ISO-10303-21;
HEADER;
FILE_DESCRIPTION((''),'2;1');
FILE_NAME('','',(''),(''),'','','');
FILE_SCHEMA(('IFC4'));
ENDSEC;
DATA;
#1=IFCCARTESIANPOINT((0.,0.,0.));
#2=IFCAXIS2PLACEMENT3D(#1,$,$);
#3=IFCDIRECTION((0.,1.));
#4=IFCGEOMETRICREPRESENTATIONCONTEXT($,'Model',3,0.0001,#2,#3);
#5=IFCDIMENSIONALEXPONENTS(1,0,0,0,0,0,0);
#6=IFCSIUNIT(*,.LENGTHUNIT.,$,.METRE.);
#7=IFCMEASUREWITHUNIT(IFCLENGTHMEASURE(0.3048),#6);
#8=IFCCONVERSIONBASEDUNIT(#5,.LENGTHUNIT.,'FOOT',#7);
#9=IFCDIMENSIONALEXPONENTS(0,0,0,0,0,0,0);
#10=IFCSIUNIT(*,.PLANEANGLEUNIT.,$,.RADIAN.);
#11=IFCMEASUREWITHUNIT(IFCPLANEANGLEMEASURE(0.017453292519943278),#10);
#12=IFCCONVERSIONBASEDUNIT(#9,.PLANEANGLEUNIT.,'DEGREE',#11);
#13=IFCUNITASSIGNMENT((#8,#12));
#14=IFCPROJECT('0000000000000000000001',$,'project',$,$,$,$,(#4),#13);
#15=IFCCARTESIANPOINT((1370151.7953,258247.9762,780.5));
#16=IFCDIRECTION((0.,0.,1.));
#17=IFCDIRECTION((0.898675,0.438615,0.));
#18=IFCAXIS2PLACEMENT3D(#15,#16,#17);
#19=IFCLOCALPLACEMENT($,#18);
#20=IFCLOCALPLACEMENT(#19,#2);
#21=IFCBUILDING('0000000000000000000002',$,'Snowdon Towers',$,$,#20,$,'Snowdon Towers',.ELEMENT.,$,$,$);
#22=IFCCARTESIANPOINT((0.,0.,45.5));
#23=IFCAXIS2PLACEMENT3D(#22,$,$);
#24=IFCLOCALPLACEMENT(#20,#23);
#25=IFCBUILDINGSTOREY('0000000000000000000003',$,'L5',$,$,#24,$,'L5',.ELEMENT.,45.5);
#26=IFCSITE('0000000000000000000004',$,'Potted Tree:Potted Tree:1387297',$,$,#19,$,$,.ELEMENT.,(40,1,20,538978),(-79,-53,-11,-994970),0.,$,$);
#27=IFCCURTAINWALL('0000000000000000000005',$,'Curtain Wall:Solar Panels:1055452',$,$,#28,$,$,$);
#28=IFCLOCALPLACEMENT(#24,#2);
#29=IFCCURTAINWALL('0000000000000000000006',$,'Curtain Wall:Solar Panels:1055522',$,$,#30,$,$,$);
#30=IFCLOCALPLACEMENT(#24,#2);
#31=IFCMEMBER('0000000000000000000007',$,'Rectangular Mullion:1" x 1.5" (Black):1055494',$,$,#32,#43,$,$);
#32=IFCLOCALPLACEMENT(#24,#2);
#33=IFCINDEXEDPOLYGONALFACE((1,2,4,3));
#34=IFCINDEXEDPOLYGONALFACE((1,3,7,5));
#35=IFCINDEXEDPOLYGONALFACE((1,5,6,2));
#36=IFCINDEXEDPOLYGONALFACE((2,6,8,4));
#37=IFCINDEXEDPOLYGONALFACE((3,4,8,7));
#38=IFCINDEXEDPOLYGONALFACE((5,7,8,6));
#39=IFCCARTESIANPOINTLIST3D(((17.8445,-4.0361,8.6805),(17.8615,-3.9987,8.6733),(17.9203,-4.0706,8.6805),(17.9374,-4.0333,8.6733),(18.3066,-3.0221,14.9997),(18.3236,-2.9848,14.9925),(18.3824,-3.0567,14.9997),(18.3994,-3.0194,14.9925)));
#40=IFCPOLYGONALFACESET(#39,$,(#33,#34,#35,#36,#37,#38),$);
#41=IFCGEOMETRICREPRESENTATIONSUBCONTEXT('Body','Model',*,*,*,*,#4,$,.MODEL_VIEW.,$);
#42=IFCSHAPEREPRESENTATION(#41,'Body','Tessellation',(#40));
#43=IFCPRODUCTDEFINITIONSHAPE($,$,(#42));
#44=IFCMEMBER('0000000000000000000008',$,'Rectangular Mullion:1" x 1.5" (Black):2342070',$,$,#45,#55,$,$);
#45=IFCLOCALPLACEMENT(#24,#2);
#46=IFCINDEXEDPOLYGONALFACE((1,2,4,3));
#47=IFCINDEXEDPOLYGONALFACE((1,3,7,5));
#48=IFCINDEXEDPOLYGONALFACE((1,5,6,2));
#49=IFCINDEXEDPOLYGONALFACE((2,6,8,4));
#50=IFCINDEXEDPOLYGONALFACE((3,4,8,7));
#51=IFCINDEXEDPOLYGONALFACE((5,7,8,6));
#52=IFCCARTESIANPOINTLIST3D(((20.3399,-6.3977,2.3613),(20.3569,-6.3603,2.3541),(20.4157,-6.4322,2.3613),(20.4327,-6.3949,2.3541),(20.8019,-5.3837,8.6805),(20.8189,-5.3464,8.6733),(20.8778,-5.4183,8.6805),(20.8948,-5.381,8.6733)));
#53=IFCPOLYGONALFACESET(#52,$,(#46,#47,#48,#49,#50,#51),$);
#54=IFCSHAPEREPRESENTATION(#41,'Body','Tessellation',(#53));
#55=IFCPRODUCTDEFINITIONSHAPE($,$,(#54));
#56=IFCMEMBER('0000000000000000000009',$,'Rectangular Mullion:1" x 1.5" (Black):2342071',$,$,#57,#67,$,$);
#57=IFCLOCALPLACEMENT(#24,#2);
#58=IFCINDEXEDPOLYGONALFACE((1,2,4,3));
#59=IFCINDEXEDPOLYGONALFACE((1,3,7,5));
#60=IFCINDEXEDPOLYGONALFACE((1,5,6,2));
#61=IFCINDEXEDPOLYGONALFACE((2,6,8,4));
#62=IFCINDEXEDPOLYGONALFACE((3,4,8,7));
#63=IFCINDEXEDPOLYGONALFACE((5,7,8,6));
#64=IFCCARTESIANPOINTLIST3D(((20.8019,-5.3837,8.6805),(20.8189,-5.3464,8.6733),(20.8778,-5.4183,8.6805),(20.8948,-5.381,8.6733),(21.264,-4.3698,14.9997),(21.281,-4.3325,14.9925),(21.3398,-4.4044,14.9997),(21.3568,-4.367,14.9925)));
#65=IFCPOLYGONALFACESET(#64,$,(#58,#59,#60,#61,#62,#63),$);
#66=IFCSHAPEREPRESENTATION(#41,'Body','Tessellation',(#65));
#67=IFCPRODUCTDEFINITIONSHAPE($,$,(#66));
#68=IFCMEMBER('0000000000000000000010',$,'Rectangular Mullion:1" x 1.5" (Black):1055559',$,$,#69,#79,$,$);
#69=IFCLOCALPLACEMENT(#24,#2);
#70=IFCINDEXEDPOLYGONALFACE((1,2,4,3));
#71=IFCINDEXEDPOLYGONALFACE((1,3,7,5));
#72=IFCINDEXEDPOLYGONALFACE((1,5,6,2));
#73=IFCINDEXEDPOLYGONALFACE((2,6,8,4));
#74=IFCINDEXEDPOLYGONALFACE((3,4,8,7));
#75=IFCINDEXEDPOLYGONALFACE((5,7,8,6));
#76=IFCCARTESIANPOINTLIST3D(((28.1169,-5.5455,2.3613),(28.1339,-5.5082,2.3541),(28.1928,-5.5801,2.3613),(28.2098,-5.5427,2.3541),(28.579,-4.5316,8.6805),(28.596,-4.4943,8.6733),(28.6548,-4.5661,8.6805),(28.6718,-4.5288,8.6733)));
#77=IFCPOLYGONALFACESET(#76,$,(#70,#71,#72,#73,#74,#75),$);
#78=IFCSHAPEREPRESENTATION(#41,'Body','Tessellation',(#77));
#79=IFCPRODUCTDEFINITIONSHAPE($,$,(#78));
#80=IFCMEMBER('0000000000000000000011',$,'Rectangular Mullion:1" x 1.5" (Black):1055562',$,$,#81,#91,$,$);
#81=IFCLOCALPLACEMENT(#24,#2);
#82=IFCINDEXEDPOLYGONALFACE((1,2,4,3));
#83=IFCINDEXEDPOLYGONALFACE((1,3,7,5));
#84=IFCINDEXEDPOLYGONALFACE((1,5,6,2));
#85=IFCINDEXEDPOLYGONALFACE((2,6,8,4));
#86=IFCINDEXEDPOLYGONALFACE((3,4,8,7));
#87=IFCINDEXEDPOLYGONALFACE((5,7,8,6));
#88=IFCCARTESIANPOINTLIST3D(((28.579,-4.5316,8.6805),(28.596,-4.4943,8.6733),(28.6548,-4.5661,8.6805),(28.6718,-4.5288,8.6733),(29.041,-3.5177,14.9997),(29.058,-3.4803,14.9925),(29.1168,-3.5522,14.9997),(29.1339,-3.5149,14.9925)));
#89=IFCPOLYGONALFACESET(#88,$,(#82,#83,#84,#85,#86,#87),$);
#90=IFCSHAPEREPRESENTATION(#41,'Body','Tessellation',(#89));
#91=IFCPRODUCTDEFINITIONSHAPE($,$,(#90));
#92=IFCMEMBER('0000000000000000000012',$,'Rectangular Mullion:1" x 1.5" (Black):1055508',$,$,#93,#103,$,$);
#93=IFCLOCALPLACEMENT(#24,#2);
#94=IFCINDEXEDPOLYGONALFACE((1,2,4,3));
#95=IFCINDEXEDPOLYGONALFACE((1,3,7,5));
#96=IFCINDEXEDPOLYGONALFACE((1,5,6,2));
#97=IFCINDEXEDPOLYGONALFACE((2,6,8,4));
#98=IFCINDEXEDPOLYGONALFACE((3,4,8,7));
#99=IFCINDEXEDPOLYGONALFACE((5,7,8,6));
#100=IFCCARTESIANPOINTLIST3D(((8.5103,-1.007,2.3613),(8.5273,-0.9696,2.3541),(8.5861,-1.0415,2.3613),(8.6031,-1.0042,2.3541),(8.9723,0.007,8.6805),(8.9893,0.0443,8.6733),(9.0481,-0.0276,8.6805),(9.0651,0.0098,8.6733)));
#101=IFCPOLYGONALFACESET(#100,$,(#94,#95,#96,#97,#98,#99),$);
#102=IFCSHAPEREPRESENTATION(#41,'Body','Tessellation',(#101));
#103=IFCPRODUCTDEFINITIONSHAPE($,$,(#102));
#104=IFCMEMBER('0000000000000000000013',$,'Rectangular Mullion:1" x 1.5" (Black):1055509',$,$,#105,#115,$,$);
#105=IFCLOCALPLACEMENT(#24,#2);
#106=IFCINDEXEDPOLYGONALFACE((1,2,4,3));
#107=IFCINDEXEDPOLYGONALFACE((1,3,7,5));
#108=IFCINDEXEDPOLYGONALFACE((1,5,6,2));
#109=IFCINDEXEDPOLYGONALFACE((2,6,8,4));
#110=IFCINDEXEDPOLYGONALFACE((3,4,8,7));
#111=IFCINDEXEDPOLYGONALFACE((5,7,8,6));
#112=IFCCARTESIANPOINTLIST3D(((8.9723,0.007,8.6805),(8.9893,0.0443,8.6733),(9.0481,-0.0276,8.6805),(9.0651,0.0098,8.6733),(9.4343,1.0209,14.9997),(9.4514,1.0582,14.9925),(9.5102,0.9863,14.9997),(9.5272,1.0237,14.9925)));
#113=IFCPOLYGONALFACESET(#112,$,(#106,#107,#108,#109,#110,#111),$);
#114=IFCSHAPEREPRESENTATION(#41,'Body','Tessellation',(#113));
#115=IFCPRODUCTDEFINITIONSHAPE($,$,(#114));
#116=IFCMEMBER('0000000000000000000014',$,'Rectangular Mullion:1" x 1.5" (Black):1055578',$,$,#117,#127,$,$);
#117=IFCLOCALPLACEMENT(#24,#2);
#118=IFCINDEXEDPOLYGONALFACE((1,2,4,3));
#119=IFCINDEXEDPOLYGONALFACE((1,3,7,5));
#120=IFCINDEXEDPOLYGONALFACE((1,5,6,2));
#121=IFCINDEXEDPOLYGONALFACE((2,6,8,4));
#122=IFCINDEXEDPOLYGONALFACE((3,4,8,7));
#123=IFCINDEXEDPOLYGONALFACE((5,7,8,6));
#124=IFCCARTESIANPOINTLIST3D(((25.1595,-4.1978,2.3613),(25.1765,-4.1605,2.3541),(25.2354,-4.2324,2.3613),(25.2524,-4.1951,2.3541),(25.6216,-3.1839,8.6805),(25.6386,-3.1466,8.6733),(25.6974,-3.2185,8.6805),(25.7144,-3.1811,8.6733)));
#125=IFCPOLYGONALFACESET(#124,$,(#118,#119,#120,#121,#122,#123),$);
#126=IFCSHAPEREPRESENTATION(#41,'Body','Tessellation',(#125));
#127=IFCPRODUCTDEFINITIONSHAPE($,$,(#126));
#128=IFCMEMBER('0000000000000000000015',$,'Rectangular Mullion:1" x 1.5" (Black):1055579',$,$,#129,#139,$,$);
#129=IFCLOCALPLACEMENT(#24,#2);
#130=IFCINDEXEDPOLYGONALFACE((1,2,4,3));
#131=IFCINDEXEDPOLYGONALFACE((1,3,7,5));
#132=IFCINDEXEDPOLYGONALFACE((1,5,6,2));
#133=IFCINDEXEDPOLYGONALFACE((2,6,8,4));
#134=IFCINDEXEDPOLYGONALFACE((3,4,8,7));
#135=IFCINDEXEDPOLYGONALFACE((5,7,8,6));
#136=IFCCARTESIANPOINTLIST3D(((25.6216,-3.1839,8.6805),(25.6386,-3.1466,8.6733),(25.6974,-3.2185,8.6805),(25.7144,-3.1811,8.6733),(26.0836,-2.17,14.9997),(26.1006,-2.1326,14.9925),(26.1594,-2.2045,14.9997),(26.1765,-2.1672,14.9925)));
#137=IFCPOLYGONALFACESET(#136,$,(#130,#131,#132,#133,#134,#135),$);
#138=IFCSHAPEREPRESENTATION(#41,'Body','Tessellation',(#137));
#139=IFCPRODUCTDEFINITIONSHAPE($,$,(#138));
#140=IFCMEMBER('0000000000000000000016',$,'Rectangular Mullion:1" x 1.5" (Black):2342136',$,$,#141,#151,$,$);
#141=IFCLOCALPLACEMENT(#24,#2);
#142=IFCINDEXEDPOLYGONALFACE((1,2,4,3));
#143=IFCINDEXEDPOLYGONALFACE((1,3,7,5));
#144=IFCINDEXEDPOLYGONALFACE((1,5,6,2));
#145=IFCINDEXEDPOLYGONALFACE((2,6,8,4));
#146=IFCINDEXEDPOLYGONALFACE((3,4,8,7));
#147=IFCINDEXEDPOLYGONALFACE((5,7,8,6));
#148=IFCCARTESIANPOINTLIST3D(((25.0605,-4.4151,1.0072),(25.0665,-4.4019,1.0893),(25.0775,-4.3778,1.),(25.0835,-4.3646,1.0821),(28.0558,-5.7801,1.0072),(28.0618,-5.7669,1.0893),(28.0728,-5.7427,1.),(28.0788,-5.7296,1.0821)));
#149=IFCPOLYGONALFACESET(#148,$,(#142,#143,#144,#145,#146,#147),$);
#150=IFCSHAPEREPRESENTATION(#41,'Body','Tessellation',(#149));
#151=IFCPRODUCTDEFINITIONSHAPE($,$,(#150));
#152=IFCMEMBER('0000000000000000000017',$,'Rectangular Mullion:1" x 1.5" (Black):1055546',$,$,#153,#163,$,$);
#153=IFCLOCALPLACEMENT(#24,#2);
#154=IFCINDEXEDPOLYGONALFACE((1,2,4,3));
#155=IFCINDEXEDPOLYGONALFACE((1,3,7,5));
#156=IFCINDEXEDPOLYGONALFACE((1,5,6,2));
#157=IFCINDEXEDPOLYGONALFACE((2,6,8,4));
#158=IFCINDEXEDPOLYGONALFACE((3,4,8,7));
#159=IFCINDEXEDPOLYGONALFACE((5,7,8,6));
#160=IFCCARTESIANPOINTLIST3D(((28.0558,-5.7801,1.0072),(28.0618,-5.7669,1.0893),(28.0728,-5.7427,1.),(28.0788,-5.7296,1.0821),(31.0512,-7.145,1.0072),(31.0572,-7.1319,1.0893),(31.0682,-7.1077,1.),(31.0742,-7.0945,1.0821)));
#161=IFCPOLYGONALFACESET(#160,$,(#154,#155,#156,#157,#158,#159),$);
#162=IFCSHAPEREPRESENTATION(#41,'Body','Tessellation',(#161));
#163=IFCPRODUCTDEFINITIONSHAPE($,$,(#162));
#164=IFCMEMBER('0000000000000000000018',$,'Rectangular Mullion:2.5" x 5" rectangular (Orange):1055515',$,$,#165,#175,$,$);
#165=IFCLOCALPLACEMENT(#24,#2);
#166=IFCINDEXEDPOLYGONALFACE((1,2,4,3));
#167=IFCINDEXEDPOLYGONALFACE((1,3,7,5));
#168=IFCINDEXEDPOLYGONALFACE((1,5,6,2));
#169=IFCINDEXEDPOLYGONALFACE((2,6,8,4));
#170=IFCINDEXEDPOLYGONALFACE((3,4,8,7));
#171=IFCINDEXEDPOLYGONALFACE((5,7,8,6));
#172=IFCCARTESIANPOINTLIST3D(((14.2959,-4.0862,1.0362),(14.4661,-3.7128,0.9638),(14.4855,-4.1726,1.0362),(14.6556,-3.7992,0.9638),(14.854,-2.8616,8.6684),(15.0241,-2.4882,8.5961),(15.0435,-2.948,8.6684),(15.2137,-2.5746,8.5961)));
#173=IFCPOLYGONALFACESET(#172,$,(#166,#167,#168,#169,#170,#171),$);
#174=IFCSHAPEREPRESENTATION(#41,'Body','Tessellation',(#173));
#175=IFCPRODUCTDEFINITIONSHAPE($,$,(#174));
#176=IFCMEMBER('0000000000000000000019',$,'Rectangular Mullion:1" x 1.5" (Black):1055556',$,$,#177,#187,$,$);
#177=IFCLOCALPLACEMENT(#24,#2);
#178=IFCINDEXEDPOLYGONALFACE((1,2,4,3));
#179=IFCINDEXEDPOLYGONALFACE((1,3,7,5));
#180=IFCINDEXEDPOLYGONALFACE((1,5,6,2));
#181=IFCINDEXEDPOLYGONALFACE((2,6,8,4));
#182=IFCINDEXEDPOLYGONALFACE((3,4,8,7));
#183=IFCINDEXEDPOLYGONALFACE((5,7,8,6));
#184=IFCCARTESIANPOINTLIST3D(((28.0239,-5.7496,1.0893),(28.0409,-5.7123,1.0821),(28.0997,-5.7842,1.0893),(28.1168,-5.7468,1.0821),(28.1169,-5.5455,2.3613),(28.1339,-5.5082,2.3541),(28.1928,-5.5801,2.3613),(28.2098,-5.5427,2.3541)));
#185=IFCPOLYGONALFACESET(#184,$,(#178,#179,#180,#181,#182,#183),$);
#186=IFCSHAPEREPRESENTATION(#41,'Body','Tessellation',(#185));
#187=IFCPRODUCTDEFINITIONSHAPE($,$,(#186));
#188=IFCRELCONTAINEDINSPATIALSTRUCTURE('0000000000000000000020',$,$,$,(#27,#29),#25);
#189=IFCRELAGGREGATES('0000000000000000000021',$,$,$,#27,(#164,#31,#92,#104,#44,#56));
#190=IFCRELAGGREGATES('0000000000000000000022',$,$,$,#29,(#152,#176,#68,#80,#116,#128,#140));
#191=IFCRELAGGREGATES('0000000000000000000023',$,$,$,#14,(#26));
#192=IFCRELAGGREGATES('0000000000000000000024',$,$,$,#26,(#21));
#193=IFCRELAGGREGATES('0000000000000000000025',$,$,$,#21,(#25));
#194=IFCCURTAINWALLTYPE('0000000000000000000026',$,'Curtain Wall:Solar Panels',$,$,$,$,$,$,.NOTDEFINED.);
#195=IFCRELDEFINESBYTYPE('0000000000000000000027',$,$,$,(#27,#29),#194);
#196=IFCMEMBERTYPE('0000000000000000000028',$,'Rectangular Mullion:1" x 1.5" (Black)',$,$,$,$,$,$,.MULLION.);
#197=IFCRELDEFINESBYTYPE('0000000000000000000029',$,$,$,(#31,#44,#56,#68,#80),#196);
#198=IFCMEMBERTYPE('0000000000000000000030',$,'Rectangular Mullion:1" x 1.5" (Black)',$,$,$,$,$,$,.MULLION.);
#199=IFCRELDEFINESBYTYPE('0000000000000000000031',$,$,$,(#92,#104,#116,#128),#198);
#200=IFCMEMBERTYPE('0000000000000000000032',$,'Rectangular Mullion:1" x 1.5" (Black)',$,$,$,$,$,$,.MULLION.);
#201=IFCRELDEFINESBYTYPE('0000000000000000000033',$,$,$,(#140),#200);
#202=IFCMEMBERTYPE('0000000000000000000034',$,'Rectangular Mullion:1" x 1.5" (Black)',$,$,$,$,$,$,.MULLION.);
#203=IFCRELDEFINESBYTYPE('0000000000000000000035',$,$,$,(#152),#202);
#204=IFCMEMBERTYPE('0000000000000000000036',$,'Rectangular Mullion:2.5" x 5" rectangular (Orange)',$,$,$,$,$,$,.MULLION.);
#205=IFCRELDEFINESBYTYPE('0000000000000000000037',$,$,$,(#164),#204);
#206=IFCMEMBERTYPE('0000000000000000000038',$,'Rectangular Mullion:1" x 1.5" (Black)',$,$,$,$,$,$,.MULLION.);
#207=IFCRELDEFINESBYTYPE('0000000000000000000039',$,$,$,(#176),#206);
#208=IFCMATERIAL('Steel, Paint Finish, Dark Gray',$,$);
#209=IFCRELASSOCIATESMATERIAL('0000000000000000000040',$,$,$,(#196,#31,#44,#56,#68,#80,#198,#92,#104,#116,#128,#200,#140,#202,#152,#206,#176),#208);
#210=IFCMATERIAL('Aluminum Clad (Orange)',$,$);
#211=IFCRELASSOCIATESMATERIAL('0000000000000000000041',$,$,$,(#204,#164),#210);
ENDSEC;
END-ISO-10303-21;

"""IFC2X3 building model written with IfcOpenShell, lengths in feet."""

from ifc_helpers import new_model, entity, si_unit, converted_unit, direction, frame, frame_2d, origin, origin_2d_with_axis, place, context, subcontext, project, spatial, rectangle, extrude, source, transform, mapped, material, type_object, type_shapes, element, aggregate, save


model = new_model("IFC2X3")

# Units and contexts
model_context = context("Model", 3, precision=0.0001, world=origin(), true_north=direction((0.0, 1.0)))
body_context = subcontext(model_context, "Body", "Model", "MODEL_VIEW")
ifc_project = project(units=[converted_unit("LENGTHUNIT", "FOOT", entity("IfcLengthMeasure", 0.3048), si_unit("LENGTHUNIT", "METRE"), dimensions=[1, 0, 0, 0, 0, 0, 0]), converted_unit("PLANEANGLEUNIT", "DEGREE", entity("IfcPlaneAngleMeasure", 0.017453292519943278), si_unit("PLANEANGLEUNIT", "RADIAN"), dimensions=[0, 0, 0, 0, 0, 0, 0])], contexts=[model_context])

# Site, building, storey
site_placement = place(None, frame((1370151.7953, 258247.9762, 780.5), z_axis=(0.0, 0.0, 1.0), x_axis=(0.898675, 0.438615, 0.0)))
site = spatial("IfcSite", under=ifc_project, at=site_placement, Name="Potted Tree:Potted Tree:1387297", CompositionType="ELEMENT", RefLatitude=(40, 1, 20, 538978), RefLongitude=(-79, -53, -11, -994970), RefElevation=0.0)
building_placement = place(site_placement, origin())
building = spatial("IfcBuilding", under=site, at=building_placement, Name="Snowdon Towers", LongName="Snowdon Towers", CompositionType="ELEMENT")
storey_placement = place(building_placement, frame((0.0, 0.0, 45.5)))
storey = spatial("IfcBuildingStorey", under=building, at=storey_placement, Name="L5", LongName="L5", CompositionType="ELEMENT", Elevation=45.5)

# Curtain wall
curtain_wall_type = type_object("IfcCurtainWallType", Name="Curtain Wall:Solar Panels", PredefinedType="NOTDEFINED")
curtain_wall_1_placement = place(storey_placement, frame((0.0, 0.0, -45.5)))
curtain_wall_1 = element("IfcCurtainWall", 1, at=curtain_wall_1_placement, inside=storey, type_object=curtain_wall_type, Name="Curtain Wall:Solar Panels:1055452")
ifc_material_1 = material(Name="Aluminum Clad (Orange)")

# Curtain wall
curtain_wall_2_placement = place(storey_placement, frame((0.0, 0.0, -45.5)))
curtain_wall_2 = element("IfcCurtainWall", 2, at=curtain_wall_2_placement, inside=storey, type_object=curtain_wall_type, Name="Curtain Wall:Solar Panels:1055522")

# Members
ifc_material_2 = material(Name="Steel, Paint Finish, Dark Gray")
member_type_1 = type_object("IfcMemberType", Name="Rectangular Mullion:1\" x 1.5\" (Black)", PredefinedType="MULLION", material=ifc_material_2)
shared_shape_1 = source(origin(), body_context, "Body", "SweptSolid", [
    extrude(rectangle(XDim=0.0833, YDim=0.0417, at=origin_2d_with_axis()), frame((0.0, 0.0208, -6.4167), z_axis=(0.0, 0.0, 1.0), x_axis=(-1.0, 0.0, 0.0)), (0.0, 0.0, 1.0), 6.4167),
])
type_shapes(member_type_1, [shared_shape_1])
member_1_placement = place(curtain_wall_1_placement, frame((17.8994, -4.016, 54.1733), z_axis=(-0.072007, -0.158015, -0.984808), x_axis=(0.909972, -0.414671, 0.0)))
member_1 = element("IfcMember", 3, at=member_1_placement, type_object=member_type_1, material=ifc_material_2, Name="Rectangular Mullion:1\" x 1.5\" (Black):1055494", context=body_context, shape_type="MappedRepresentation", body=[
    mapped(shared_shape_1, transform((0.0, 0.0, 0.0), scale=1.0)),
])
member_2_placement = place(curtain_wall_1_placement, frame((20.3948, -6.3776, 47.8541), z_axis=(-0.072007, -0.158015, -0.984808), x_axis=(0.909972, -0.414671, 0.0)))
member_2 = element("IfcMember", 4, at=member_2_placement, type_object=member_type_1, material=ifc_material_2, Name="Rectangular Mullion:1\" x 1.5\" (Black):2342070", context=body_context, shape_type="MappedRepresentation", body=[
    mapped(shared_shape_1, transform((0.0, 0.0, 0.0), scale=1.0)),
])
member_3_placement = place(curtain_wall_1_placement, frame((20.8569, -5.3637, 54.1733), z_axis=(-0.072007, -0.158015, -0.984808), x_axis=(0.909972, -0.414671, 0.0)))
member_3 = element("IfcMember", 5, at=member_3_placement, type_object=member_type_1, material=ifc_material_2, Name="Rectangular Mullion:1\" x 1.5\" (Black):2342071", context=body_context, shape_type="MappedRepresentation", body=[
    mapped(shared_shape_1, transform((0.0, 0.0, 0.0), scale=1.0)),
])
member_4_placement = place(curtain_wall_2_placement, frame((28.1719, -5.5255, 47.8541), z_axis=(-0.072007, -0.158015, -0.984808), x_axis=(0.909972, -0.414671, 0.0)))
member_4 = element("IfcMember", 6, at=member_4_placement, type_object=member_type_1, material=ifc_material_2, Name="Rectangular Mullion:1\" x 1.5\" (Black):1055559", context=body_context, shape_type="MappedRepresentation", body=[
    mapped(shared_shape_1, transform((0.0, 0.0, 0.0), scale=1.0)),
])
member_5_placement = place(curtain_wall_2_placement, frame((28.6339, -4.5115, 54.1733), z_axis=(-0.072007, -0.158015, -0.984808), x_axis=(0.909972, -0.414671, 0.0)))
member_5 = element("IfcMember", 7, at=member_5_placement, type_object=member_type_1, material=ifc_material_2, Name="Rectangular Mullion:1\" x 1.5\" (Black):1055562", context=body_context, shape_type="MappedRepresentation", body=[
    mapped(shared_shape_1, transform((0.0, 0.0, 0.0), scale=1.0)),
])
member_type_2 = type_object("IfcMemberType", Name="Rectangular Mullion:1\" x 1.5\" (Black)", PredefinedType="MULLION", material=ifc_material_2)
shared_shape_2 = source(origin(), body_context, "Body", "SweptSolid", [
    extrude(rectangle(XDim=0.0833, YDim=0.0417, at=frame_2d((0.0, 0.0), x_axis=(1.0, 0.0))), frame((-0.0417, 0.0208, -6.4167), z_axis=(0.0, 0.0, 1.0), x_axis=(-1.0, 0.0, 0.0)), (0.0, 0.0, 1.0), 6.4167),
])
type_shapes(member_type_2, [shared_shape_2])
member_6_placement = place(curtain_wall_1_placement, frame((8.9893, 0.0443, 54.1733), z_axis=(0.072007, 0.158015, 0.984808), x_axis=(-0.909972, 0.414671, 0.0)))
member_6 = element("IfcMember", 8, at=member_6_placement, type_object=member_type_2, material=ifc_material_2, Name="Rectangular Mullion:1\" x 1.5\" (Black):1055508", context=body_context, shape_type="MappedRepresentation", body=[
    mapped(shared_shape_2, transform((0.0, 0.0, 0.0), scale=1.0)),
])
member_7_placement = place(curtain_wall_1_placement, frame((9.4514, 1.0582, 60.4925), z_axis=(0.072007, 0.158015, 0.984808), x_axis=(-0.909972, 0.414671, 0.0)))
member_7 = element("IfcMember", 9, at=member_7_placement, type_object=member_type_2, material=ifc_material_2, Name="Rectangular Mullion:1\" x 1.5\" (Black):1055509", context=body_context, shape_type="MappedRepresentation", body=[
    mapped(shared_shape_2, transform((0.0, 0.0, 0.0), scale=1.0)),
])
member_8_placement = place(curtain_wall_2_placement, frame((25.6386, -3.1466, 54.1733), z_axis=(0.072007, 0.158015, 0.984808), x_axis=(-0.909972, 0.414671, 0.0)))
member_8 = element("IfcMember", 10, at=member_8_placement, type_object=member_type_2, material=ifc_material_2, Name="Rectangular Mullion:1\" x 1.5\" (Black):1055578", context=body_context, shape_type="MappedRepresentation", body=[
    mapped(shared_shape_2, transform((0.0, 0.0, 0.0), scale=1.0)),
])
member_9_placement = place(curtain_wall_2_placement, frame((26.1006, -2.1326, 60.4925), z_axis=(0.072007, 0.158015, 0.984808), x_axis=(-0.909972, 0.414671, 0.0)))
member_9 = element("IfcMember", 11, at=member_9_placement, type_object=member_type_2, material=ifc_material_2, Name="Rectangular Mullion:1\" x 1.5\" (Black):1055579", context=body_context, shape_type="MappedRepresentation", body=[
    mapped(shared_shape_2, transform((0.0, 0.0, 0.0), scale=1.0)),
])
member_type_3 = type_object("IfcMemberType", Name="Rectangular Mullion:1\" x 1.5\" (Black)", PredefinedType="MULLION", material=ifc_material_2)
shared_shape_3 = source(origin(), body_context, "Body", "SweptSolid", [
    extrude(rectangle(XDim=0.0833, YDim=0.0417, at=origin_2d_with_axis()), frame((-0.0417, 0.0208, -3.2917), z_axis=(0.0, 0.0, 1.0), x_axis=(-1.0, 0.0, 0.0)), (0.0, 0.0, 1.0), 3.2917),
])
type_shapes(member_type_3, [shared_shape_3])
member_10_placement = place(curtain_wall_2_placement, frame((25.0775, -4.3778, 46.5), z_axis=(-0.909972, 0.414671, 0.0), x_axis=(-0.072007, -0.158015, -0.984808)))
member_10 = element("IfcMember", 12, at=member_10_placement, type_object=member_type_3, material=ifc_material_2, Name="Rectangular Mullion:1\" x 1.5\" (Black):2342136", context=body_context, shape_type="MappedRepresentation", body=[
    mapped(shared_shape_3, transform((0.0, 0.0, 0.0), scale=1.0)),
])
member_type_4 = type_object("IfcMemberType", Name="Rectangular Mullion:1\" x 1.5\" (Black)", PredefinedType="MULLION", material=ifc_material_2)
shared_shape_4 = source(origin(), body_context, "Body", "SweptSolid", [
    extrude(rectangle(XDim=0.0833, YDim=0.0417, at=frame_2d((0.0, 0.0), x_axis=(1.0, 0.0))), frame((-0.0417, 0.0208, -3.2917), z_axis=(0.0, 0.0, 1.0), x_axis=(-1.0, 0.0, 0.0)), (0.0, 0.0, 1.0), 3.2917),
])
type_shapes(member_type_4, [shared_shape_4])
member_11_placement = place(curtain_wall_2_placement, frame((28.0728, -5.7427, 46.5), z_axis=(-0.909972, 0.414671, 0.0), x_axis=(-0.072007, -0.158015, -0.984808)))
member_11 = element("IfcMember", 13, at=member_11_placement, type_object=member_type_4, material=ifc_material_2, Name="Rectangular Mullion:1\" x 1.5\" (Black):1055546", context=body_context, shape_type="MappedRepresentation", body=[
    mapped(shared_shape_4, transform((0.0, 0.0, 0.0), scale=1.0)),
])
member_type_5 = type_object("IfcMemberType", Name="Rectangular Mullion:2.5\" x 5\" rectangular (Orange)", PredefinedType="MULLION", material=ifc_material_1)
shared_shape_5 = source(origin(), body_context, "Body", "SweptSolid", [
    extrude(rectangle(XDim=0.2083, YDim=0.4167, at=frame_2d((0.0, 0.0), x_axis=(1.0, 0.0))), frame((-0.1042, 0.0, -7.75), z_axis=(0.0, 0.0, 1.0), x_axis=(-1.0, 0.0, 0.0)), (0.0, 0.0, 1.0), 7.75),
])
type_shapes(member_type_5, [shared_shape_5])
member_12_placement = place(curtain_wall_1_placement, frame((14.939, -2.6749, 54.1323), z_axis=(0.072007, 0.158015, 0.984808), x_axis=(-0.909972, 0.414671, 0.0)))
member_12 = element("IfcMember", 14, at=member_12_placement, type_object=member_type_5, material=ifc_material_1, Name="Rectangular Mullion:2.5\" x 5\" rectangular (Orange):1055515", context=body_context, shape_type="MappedRepresentation", body=[
    mapped(shared_shape_5, transform((0.0, 0.0, 0.0), scale=1.0)),
])
member_type_6 = type_object("IfcMemberType", Name="Rectangular Mullion:1\" x 1.5\" (Black)", PredefinedType="MULLION", material=ifc_material_2)
shared_shape_6 = source(origin(), body_context, "Body", "SweptSolid", [
    extrude(rectangle(XDim=0.0833, YDim=0.0417, at=origin_2d_with_axis()), frame((0.0, 0.0208, -1.2917), z_axis=(0.0, 0.0, 1.0), x_axis=(-1.0, 0.0, 0.0)), (0.0, 0.0, 1.0), 1.2917),
])
type_shapes(member_type_6, [shared_shape_6])
member_13_placement = place(curtain_wall_2_placement, frame((28.0788, -5.7296, 46.5821), z_axis=(-0.072007, -0.158015, -0.984808), x_axis=(0.909972, -0.414671, 0.0)))
member_13 = element("IfcMember", 15, at=member_13_placement, type_object=member_type_6, material=ifc_material_2, Name="Rectangular Mullion:1\" x 1.5\" (Black):1055556", context=body_context, shape_type="MappedRepresentation", body=[
    mapped(shared_shape_6, transform((0.0, 0.0, 0.0), scale=1.0)),
])

aggregate(curtain_wall_1, [member_12, member_1, member_6, member_7, member_2, member_3])
aggregate(curtain_wall_2, [member_11, member_13, member_4, member_5, member_8, member_9, member_10])

save(model, "model.ifc")
